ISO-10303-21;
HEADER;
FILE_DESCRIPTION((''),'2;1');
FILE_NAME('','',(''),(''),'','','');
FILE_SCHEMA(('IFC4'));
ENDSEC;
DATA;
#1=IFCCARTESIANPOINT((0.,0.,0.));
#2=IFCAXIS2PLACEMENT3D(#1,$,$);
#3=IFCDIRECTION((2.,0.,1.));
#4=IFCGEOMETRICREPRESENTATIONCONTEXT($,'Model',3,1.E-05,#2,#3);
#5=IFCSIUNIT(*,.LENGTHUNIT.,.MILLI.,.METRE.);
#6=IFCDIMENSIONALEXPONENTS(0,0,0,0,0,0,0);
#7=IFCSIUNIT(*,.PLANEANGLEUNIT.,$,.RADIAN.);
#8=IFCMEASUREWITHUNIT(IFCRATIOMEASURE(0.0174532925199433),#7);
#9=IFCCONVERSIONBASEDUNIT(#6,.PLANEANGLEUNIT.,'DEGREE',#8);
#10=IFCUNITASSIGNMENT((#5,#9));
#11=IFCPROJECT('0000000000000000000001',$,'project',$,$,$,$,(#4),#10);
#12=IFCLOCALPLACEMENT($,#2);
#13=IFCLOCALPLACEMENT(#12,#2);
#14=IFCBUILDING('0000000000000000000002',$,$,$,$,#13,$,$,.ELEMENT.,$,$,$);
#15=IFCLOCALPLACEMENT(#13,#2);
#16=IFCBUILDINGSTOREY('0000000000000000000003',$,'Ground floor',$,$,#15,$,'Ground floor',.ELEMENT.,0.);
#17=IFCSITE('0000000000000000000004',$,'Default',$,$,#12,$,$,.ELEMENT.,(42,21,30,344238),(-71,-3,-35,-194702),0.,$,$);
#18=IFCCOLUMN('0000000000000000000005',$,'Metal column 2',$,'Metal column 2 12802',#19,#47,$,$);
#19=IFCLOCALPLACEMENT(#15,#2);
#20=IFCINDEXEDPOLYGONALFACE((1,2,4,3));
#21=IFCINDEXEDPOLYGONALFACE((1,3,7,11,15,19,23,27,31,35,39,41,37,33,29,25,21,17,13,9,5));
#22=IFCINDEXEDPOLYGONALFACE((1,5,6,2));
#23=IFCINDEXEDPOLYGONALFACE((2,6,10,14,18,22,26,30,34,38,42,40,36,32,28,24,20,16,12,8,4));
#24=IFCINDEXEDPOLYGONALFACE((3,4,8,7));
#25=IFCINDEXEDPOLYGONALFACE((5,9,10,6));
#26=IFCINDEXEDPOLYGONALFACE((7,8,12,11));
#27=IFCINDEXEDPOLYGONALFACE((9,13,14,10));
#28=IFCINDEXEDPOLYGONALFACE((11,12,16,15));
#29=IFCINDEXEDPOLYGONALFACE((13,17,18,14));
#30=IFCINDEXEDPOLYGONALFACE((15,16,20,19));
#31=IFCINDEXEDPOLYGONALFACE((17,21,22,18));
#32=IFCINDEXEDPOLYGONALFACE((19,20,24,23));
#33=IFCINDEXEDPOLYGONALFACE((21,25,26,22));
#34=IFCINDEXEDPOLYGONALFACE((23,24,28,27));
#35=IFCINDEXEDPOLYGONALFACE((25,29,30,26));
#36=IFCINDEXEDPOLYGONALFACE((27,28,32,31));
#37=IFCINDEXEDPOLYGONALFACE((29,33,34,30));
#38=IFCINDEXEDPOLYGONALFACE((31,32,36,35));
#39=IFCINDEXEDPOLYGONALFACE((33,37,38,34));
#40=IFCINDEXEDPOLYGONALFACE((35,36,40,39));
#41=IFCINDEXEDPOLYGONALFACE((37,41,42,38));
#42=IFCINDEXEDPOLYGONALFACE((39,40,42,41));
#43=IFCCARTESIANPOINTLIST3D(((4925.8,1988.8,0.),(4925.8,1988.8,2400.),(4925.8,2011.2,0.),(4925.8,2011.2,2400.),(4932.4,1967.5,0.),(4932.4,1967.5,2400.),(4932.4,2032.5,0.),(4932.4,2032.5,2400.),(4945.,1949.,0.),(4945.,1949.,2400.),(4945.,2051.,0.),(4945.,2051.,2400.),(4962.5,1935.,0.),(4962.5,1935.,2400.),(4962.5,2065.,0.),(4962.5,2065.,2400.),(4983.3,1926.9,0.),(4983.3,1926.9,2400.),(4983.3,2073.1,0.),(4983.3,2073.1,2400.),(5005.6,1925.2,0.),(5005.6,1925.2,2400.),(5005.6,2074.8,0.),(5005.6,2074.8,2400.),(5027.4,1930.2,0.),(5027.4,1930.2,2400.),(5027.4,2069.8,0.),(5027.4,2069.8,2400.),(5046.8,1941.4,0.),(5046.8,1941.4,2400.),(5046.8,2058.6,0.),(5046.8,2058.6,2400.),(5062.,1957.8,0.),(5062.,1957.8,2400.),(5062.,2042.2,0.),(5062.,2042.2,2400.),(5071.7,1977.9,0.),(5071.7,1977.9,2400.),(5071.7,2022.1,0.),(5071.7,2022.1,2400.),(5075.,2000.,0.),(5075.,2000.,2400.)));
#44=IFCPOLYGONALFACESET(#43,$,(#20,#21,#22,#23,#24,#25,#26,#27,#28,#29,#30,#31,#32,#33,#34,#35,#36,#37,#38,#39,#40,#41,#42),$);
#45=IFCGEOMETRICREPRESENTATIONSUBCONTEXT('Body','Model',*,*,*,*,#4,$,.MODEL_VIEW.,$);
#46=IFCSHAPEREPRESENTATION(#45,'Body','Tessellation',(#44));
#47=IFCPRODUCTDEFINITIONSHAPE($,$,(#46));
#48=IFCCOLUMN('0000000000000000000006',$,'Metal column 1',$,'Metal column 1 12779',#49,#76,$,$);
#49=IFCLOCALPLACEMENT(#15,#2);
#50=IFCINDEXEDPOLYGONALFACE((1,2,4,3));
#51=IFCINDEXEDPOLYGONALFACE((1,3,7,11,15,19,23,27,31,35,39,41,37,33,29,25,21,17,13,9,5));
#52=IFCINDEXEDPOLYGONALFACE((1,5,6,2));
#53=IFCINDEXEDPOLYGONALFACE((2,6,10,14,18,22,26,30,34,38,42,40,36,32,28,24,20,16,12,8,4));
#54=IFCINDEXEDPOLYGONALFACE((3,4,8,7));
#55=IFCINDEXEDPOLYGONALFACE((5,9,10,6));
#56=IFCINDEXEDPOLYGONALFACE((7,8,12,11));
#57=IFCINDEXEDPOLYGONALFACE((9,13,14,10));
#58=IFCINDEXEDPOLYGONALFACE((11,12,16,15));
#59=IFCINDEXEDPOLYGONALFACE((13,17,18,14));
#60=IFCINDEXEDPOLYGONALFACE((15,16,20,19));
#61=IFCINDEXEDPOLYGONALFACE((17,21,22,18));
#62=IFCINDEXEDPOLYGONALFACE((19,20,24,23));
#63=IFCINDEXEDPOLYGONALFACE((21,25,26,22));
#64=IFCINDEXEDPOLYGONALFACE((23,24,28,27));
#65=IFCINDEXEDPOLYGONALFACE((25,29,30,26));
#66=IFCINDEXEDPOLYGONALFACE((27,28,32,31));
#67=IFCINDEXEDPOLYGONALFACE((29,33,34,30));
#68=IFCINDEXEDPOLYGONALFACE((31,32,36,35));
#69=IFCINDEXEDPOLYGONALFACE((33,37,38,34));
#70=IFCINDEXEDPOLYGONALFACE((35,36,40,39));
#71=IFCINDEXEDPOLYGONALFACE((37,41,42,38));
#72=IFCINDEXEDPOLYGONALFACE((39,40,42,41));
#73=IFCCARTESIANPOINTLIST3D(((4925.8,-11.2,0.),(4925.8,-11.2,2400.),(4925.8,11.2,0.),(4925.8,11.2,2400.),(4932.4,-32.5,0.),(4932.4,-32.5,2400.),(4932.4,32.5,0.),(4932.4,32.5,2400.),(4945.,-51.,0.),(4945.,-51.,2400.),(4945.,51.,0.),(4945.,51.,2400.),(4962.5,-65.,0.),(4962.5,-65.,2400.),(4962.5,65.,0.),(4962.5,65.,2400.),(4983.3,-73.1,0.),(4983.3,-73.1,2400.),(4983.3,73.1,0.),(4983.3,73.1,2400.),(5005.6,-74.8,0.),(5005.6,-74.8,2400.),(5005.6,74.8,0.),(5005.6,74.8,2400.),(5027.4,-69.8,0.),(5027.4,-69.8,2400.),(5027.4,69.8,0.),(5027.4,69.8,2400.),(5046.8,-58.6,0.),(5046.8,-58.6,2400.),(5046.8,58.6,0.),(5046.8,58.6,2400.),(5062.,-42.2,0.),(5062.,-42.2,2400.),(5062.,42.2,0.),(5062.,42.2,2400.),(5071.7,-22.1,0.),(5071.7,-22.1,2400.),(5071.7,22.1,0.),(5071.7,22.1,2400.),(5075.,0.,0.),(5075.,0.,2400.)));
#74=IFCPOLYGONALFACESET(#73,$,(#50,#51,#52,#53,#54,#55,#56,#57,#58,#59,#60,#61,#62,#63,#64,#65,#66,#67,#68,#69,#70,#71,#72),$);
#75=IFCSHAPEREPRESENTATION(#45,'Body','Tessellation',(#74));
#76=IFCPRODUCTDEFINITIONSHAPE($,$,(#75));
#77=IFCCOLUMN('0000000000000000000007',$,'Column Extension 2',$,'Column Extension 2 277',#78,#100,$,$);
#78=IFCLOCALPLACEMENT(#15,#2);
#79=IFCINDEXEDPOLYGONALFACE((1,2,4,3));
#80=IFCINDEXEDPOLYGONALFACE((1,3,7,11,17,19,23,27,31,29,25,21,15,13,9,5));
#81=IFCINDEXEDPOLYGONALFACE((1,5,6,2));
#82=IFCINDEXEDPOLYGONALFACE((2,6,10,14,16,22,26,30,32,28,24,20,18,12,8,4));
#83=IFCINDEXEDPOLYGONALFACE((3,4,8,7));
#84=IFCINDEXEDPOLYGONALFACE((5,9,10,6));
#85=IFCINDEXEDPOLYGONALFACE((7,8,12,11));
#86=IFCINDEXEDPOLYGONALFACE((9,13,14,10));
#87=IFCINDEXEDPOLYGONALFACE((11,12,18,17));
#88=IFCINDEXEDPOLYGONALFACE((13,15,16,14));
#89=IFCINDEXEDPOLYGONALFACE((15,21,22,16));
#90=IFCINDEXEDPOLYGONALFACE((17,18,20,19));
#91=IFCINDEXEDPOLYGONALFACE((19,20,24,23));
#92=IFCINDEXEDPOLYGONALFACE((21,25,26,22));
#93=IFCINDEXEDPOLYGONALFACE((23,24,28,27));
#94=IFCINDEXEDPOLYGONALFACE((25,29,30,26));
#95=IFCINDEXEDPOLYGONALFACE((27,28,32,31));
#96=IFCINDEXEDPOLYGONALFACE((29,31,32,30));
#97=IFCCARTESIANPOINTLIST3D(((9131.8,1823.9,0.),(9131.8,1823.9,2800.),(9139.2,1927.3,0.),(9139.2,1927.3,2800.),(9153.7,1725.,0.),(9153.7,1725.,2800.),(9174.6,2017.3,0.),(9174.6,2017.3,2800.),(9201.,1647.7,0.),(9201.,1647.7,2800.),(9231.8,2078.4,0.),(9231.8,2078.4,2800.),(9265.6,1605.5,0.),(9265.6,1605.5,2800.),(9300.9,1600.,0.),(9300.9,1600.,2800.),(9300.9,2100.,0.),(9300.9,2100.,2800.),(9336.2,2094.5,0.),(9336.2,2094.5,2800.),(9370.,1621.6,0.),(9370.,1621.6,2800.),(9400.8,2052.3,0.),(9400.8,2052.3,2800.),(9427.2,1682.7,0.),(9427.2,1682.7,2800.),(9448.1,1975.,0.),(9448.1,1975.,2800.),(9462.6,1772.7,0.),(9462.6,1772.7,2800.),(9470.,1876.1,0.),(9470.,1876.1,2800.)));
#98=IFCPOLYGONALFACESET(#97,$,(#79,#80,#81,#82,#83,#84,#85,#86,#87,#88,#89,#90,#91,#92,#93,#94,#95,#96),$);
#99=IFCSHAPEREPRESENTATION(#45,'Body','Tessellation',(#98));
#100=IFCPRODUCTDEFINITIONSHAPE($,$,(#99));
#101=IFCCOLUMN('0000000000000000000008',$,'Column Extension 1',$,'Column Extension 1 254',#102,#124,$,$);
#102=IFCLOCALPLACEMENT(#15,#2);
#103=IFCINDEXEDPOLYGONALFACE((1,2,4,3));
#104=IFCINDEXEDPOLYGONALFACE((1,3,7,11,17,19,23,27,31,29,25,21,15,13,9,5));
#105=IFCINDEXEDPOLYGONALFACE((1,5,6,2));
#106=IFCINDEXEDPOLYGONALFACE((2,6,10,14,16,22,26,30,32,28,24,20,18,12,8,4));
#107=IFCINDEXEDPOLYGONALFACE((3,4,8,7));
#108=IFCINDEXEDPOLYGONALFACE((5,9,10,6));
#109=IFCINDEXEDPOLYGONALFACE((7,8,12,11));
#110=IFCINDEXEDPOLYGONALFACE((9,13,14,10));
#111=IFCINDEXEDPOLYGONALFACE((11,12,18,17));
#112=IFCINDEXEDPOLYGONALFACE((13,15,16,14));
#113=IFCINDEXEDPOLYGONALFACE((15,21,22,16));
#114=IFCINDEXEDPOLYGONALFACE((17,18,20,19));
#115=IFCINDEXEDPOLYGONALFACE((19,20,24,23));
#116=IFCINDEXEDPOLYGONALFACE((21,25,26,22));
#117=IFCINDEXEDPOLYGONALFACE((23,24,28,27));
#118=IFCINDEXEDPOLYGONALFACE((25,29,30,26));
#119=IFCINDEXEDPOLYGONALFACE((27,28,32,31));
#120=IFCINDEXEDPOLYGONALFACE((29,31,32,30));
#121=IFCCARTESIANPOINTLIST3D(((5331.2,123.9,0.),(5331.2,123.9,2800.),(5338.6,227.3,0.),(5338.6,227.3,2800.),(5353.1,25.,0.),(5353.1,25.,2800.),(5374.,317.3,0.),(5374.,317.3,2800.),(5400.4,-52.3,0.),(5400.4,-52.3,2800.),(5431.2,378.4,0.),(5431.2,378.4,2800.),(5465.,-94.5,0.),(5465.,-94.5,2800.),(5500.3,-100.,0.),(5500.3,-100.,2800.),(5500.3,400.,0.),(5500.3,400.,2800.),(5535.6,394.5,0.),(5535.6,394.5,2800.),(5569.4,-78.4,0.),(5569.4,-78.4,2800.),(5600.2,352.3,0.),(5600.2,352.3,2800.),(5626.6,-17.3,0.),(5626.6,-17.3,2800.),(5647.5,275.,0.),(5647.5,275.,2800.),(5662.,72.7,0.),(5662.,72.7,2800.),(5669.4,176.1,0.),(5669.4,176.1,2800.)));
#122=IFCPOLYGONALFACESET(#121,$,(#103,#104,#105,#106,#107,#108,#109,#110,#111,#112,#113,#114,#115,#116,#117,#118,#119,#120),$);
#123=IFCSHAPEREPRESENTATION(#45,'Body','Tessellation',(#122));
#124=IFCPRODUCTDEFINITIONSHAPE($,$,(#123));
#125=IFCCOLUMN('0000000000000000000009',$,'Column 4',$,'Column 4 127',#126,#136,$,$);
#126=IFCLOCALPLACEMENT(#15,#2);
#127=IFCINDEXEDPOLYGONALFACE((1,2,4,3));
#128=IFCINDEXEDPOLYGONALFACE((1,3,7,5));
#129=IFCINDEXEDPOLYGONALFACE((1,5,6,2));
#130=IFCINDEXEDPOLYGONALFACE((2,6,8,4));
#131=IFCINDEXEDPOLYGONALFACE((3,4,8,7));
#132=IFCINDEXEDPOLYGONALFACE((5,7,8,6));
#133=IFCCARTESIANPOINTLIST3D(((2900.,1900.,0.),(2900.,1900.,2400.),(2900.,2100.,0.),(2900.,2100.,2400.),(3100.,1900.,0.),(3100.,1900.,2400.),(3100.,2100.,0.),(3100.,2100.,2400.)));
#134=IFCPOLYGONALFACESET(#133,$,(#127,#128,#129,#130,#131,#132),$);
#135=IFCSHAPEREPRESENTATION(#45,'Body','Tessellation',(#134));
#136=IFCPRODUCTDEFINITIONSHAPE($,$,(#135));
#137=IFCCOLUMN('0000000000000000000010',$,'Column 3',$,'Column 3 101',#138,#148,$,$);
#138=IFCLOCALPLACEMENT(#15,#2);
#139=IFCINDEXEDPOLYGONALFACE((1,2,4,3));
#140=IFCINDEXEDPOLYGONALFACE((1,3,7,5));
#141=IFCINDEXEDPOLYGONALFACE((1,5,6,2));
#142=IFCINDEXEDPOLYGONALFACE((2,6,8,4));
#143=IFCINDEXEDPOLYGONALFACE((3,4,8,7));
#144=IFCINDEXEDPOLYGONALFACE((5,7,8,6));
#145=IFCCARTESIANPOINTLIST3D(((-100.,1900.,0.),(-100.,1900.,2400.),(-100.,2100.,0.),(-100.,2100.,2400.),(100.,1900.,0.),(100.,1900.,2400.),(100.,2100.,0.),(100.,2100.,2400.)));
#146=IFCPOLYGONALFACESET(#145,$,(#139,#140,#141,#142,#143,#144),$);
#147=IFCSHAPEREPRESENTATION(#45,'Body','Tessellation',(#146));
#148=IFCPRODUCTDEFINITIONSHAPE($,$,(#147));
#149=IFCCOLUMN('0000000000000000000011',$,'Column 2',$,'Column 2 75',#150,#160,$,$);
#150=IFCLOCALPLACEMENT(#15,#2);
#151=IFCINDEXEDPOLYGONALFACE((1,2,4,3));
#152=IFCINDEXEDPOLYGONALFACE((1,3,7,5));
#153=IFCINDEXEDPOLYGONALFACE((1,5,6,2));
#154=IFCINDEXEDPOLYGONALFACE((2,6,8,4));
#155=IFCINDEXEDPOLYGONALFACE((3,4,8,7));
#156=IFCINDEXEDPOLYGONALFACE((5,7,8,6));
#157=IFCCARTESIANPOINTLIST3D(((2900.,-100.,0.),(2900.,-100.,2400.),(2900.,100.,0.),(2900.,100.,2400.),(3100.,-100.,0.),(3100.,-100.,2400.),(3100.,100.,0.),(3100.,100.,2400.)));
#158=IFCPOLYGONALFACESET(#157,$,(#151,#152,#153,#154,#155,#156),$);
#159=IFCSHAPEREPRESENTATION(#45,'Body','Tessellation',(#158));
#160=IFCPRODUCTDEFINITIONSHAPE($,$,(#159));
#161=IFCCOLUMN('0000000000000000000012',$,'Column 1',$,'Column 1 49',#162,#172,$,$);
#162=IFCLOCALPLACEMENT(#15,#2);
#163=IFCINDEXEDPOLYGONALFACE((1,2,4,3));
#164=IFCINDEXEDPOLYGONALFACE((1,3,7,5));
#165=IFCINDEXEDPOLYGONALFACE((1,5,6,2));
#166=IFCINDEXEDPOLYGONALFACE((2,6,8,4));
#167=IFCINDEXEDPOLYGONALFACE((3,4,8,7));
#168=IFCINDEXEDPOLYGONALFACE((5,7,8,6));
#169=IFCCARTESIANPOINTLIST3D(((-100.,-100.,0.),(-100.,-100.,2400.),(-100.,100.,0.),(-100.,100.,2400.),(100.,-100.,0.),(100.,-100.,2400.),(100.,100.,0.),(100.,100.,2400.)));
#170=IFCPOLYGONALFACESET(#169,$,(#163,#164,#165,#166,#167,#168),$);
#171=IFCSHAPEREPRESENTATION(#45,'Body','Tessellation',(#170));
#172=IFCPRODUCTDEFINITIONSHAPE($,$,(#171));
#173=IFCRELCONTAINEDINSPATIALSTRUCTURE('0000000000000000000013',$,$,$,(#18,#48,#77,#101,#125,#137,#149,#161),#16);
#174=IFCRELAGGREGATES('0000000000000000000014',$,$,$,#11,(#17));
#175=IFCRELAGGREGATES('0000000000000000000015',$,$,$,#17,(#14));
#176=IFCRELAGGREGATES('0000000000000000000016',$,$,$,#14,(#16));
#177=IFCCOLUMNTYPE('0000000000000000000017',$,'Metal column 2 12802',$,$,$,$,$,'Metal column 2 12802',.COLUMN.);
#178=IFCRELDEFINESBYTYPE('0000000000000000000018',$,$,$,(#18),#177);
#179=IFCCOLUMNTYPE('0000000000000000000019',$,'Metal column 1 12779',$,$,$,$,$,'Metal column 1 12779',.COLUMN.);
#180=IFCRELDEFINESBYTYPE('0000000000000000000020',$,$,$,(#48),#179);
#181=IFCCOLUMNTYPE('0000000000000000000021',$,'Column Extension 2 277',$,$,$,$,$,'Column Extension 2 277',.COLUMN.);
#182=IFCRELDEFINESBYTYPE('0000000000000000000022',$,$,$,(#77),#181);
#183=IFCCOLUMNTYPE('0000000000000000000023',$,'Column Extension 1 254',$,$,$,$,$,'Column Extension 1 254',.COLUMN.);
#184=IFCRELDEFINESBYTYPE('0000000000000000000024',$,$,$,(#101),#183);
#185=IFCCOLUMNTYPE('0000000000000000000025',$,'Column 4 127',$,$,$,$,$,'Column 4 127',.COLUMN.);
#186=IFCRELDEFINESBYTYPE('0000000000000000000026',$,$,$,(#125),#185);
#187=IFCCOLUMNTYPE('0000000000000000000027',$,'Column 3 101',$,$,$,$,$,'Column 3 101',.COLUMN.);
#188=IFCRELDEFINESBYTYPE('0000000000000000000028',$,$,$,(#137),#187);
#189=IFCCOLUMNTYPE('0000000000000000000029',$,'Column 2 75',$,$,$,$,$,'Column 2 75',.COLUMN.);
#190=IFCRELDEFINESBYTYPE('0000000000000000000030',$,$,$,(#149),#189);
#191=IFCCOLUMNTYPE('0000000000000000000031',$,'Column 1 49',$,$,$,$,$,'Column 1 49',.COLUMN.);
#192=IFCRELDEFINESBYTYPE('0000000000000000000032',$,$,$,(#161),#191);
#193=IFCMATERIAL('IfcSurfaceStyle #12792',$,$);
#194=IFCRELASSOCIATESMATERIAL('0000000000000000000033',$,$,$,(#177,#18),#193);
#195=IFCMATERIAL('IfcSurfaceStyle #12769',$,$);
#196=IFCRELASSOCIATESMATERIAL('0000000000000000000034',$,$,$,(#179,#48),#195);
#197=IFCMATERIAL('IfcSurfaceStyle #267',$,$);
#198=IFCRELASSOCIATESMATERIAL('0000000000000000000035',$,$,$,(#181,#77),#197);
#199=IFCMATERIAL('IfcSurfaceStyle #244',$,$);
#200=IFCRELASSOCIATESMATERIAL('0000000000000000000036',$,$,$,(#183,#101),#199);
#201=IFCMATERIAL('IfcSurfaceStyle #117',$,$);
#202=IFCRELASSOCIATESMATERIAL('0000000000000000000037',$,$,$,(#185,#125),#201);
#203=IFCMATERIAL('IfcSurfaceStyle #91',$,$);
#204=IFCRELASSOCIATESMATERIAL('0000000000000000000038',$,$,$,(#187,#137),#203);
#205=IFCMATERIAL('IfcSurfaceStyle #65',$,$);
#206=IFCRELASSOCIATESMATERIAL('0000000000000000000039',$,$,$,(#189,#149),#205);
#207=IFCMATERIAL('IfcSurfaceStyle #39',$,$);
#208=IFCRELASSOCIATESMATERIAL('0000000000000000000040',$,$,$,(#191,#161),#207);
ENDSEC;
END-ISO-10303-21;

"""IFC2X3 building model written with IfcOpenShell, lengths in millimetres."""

from ifc_helpers import new_model, entity, si_unit, converted_unit, direction, frame_2d, origin, place, context, subcontext, project, spatial, polyline, rectangle, circle, outline, extrude, source, transform, mapped, material, type_object, type_shapes, element, save


model = new_model("IFC2X3")

# Units and contexts
model_context = context("Model", 3, precision=1e-05, world=origin(), true_north=direction((2.0, 0.0, 1.0)))
body_context = subcontext(model_context, "Body", "Model", "MODEL_VIEW")
ifc_project = project(units=[si_unit("LENGTHUNIT", "METRE", prefix="MILLI"), converted_unit("PLANEANGLEUNIT", "DEGREE", entity("IfcRatioMeasure", 0.0174532925199433), si_unit("PLANEANGLEUNIT", "RADIAN"), dimensions=[0, 0, 0, 0, 0, 0, 0])], contexts=[model_context])

# Site, building, storey
site_placement = place(None, origin())
site = spatial("IfcSite", under=ifc_project, at=site_placement, Name="Default", CompositionType="ELEMENT", RefLatitude=(42, 21, 30, 344238), RefLongitude=(-71, -3, -35, -194702), RefElevation=0.0)
building_placement = place(site_placement, origin())
building = spatial("IfcBuilding", under=site, at=building_placement, CompositionType="ELEMENT")
storey_placement = place(building_placement, origin())
storey = spatial("IfcBuildingStorey", under=building, at=storey_placement, Name="Ground floor", LongName="Ground floor", CompositionType="ELEMENT", Elevation=0.0)

# Columns
ifc_material_1 = material(Name="IfcSurfaceStyle #12792")
column_type_1 = type_object("IfcColumnType", Name="Metal column 2 12802", ElementType="Metal column 2 12802", PredefinedType="COLUMN", material=ifc_material_1)
shared_shape_1 = source(origin(), body_context, "Body", "SweptSolid", [
    extrude(circle(Radius=75.0, at=frame_2d((5000.0, 2000.0), x_axis=(1.0, 0.0))), origin(), (0.0, 0.0, 1.0), 2400.0),
])
type_shapes(column_type_1, [shared_shape_1])
column_1_placement = place(storey_placement, origin())
element("IfcColumn", 1, at=column_1_placement, inside=storey, type_object=column_type_1, material=ifc_material_1, Name="Metal column 2", ObjectType="Metal column 2 12802", context=body_context, shape_type="MappedRepresentation", body=[
    mapped(shared_shape_1, transform((0.0, 0.0, 0.0), scale=1.0)),
])
ifc_material_2 = material(Name="IfcSurfaceStyle #12769")
column_type_2 = type_object("IfcColumnType", Name="Metal column 1 12779", ElementType="Metal column 1 12779", PredefinedType="COLUMN", material=ifc_material_2)
shared_shape_2 = source(origin(), body_context, "Body", "SweptSolid", [
    extrude(circle(Radius=75.0, at=frame_2d((5000.0, 0.0), x_axis=(1.0, 0.0))), origin(), (0.0, 0.0, 1.0), 2400.0),
])
type_shapes(column_type_2, [shared_shape_2])
column_2_placement = place(storey_placement, origin())
element("IfcColumn", 2, at=column_2_placement, inside=storey, type_object=column_type_2, material=ifc_material_2, Name="Metal column 1", ObjectType="Metal column 1 12779", context=body_context, shape_type="MappedRepresentation", body=[
    mapped(shared_shape_2, transform((0.0, 0.0, 0.0), scale=1.0)),
])
ifc_material_3 = material(Name="IfcSurfaceStyle #267")
column_type_3 = type_object("IfcColumnType", Name="Column Extension 2 277", ElementType="Column Extension 2 277", PredefinedType="COLUMN", material=ifc_material_3)
shared_shape_3 = source(origin(), body_context, "Body", "SweptSolid", [
    extrude(outline(polyline([(9300.9, 2100.0), (9231.8, 2078.4), (9174.6, 2017.3), (9139.2, 1927.3), (9131.8, 1823.9), (9153.7, 1725.0), (9201.0, 1647.7), (9265.6, 1605.5), (9300.9, 1600.0), (9370.0, 1621.6), (9427.2, 1682.7), (9462.6, 1772.7), (9470.0, 1876.1), (9448.1, 1975.0), (9400.8, 2052.3), (9336.2, 2094.5), (9300.9, 2100.0)])), origin(), (0.0, 0.0, 1.0), 2800.0),
])
type_shapes(column_type_3, [shared_shape_3])
column_3_placement = place(storey_placement, origin())
element("IfcColumn", 3, at=column_3_placement, inside=storey, type_object=column_type_3, material=ifc_material_3, Name="Column Extension 2", ObjectType="Column Extension 2 277", context=body_context, shape_type="MappedRepresentation", body=[
    mapped(shared_shape_3, transform((0.0, 0.0, 0.0), scale=1.0)),
])
ifc_material_4 = material(Name="IfcSurfaceStyle #244")
column_type_4 = type_object("IfcColumnType", Name="Column Extension 1 254", ElementType="Column Extension 1 254", PredefinedType="COLUMN", material=ifc_material_4)
shared_shape_4 = source(origin(), body_context, "Body", "SweptSolid", [
    extrude(outline(polyline([(5500.3, 400.0), (5431.2, 378.4), (5374.0, 317.3), (5338.6, 227.3), (5331.2, 123.9), (5353.1, 25.0), (5400.4, -52.3), (5465.0, -94.5), (5500.3, -100.0), (5569.4, -78.4), (5626.6, -17.3), (5662.0, 72.7), (5669.4, 176.1), (5647.5, 275.0), (5600.2, 352.3), (5535.6, 394.5), (5500.3, 400.0)])), origin(), (0.0, 0.0, 1.0), 2800.0),
])
type_shapes(column_type_4, [shared_shape_4])
column_4_placement = place(storey_placement, origin())
element("IfcColumn", 4, at=column_4_placement, inside=storey, type_object=column_type_4, material=ifc_material_4, Name="Column Extension 1", ObjectType="Column Extension 1 254", context=body_context, shape_type="MappedRepresentation", body=[
    mapped(shared_shape_4, transform((0.0, 0.0, 0.0), scale=1.0)),
])
ifc_material_5 = material(Name="IfcSurfaceStyle #117")
column_type_5 = type_object("IfcColumnType", Name="Column 4 127", ElementType="Column 4 127", PredefinedType="COLUMN", material=ifc_material_5)
shared_shape_5 = source(origin(), body_context, "Body", "SweptSolid", [
    extrude(rectangle(XDim=200.0, YDim=200.0, at=frame_2d((3000.0, 2000.0), x_axis=(-1.0, 0.0))), origin(), (0.0, 0.0, 1.0), 2400.0),
])
type_shapes(column_type_5, [shared_shape_5])
column_5_placement = place(storey_placement, origin())
element("IfcColumn", 5, at=column_5_placement, inside=storey, type_object=column_type_5, material=ifc_material_5, Name="Column 4", ObjectType="Column 4 127", context=body_context, shape_type="MappedRepresentation", body=[
    mapped(shared_shape_5, transform((0.0, 0.0, 0.0), scale=1.0)),
])
ifc_material_6 = material(Name="IfcSurfaceStyle #91")
column_type_6 = type_object("IfcColumnType", Name="Column 3 101", ElementType="Column 3 101", PredefinedType="COLUMN", material=ifc_material_6)
shared_shape_6 = source(origin(), body_context, "Body", "SweptSolid", [
    extrude(rectangle(XDim=200.0, YDim=200.0, at=frame_2d((0.0, 2000.0), x_axis=(-1.0, 0.0))), origin(), (0.0, 0.0, 1.0), 2400.0),
])
type_shapes(column_type_6, [shared_shape_6])
column_6_placement = place(storey_placement, origin())
element("IfcColumn", 6, at=column_6_placement, inside=storey, type_object=column_type_6, material=ifc_material_6, Name="Column 3", ObjectType="Column 3 101", context=body_context, shape_type="MappedRepresentation", body=[
    mapped(shared_shape_6, transform((0.0, 0.0, 0.0), scale=1.0)),
])
ifc_material_7 = material(Name="IfcSurfaceStyle #65")
column_type_7 = type_object("IfcColumnType", Name="Column 2 75", ElementType="Column 2 75", PredefinedType="COLUMN", material=ifc_material_7)
shared_shape_7 = source(origin(), body_context, "Body", "SweptSolid", [
    extrude(rectangle(XDim=200.0, YDim=200.0, at=frame_2d((3000.0, 0.0), x_axis=(-1.0, 0.0))), origin(), (0.0, 0.0, 1.0), 2400.0),
])
type_shapes(column_type_7, [shared_shape_7])
column_7_placement = place(storey_placement, origin())
element("IfcColumn", 7, at=column_7_placement, inside=storey, type_object=column_type_7, material=ifc_material_7, Name="Column 2", ObjectType="Column 2 75", context=body_context, shape_type="MappedRepresentation", body=[
    mapped(shared_shape_7, transform((0.0, 0.0, 0.0), scale=1.0)),
])
ifc_material_8 = material(Name="IfcSurfaceStyle #39")
column_type_8 = type_object("IfcColumnType", Name="Column 1 49", ElementType="Column 1 49", PredefinedType="COLUMN", material=ifc_material_8)
shared_shape_8 = source(origin(), body_context, "Body", "SweptSolid", [
    extrude(rectangle(XDim=200.0, YDim=200.0, at=frame_2d((0.0, 0.0), x_axis=(-1.0, 0.0))), origin(), (0.0, 0.0, 1.0), 2400.0),
])
type_shapes(column_type_8, [shared_shape_8])
column_8_placement = place(storey_placement, origin())
element("IfcColumn", 8, at=column_8_placement, inside=storey, type_object=column_type_8, material=ifc_material_8, Name="Column 1", ObjectType="Column 1 49", context=body_context, shape_type="MappedRepresentation", body=[
    mapped(shared_shape_8, transform((0.0, 0.0, 0.0), scale=1.0)),
])

save(model, "model.ifc")
